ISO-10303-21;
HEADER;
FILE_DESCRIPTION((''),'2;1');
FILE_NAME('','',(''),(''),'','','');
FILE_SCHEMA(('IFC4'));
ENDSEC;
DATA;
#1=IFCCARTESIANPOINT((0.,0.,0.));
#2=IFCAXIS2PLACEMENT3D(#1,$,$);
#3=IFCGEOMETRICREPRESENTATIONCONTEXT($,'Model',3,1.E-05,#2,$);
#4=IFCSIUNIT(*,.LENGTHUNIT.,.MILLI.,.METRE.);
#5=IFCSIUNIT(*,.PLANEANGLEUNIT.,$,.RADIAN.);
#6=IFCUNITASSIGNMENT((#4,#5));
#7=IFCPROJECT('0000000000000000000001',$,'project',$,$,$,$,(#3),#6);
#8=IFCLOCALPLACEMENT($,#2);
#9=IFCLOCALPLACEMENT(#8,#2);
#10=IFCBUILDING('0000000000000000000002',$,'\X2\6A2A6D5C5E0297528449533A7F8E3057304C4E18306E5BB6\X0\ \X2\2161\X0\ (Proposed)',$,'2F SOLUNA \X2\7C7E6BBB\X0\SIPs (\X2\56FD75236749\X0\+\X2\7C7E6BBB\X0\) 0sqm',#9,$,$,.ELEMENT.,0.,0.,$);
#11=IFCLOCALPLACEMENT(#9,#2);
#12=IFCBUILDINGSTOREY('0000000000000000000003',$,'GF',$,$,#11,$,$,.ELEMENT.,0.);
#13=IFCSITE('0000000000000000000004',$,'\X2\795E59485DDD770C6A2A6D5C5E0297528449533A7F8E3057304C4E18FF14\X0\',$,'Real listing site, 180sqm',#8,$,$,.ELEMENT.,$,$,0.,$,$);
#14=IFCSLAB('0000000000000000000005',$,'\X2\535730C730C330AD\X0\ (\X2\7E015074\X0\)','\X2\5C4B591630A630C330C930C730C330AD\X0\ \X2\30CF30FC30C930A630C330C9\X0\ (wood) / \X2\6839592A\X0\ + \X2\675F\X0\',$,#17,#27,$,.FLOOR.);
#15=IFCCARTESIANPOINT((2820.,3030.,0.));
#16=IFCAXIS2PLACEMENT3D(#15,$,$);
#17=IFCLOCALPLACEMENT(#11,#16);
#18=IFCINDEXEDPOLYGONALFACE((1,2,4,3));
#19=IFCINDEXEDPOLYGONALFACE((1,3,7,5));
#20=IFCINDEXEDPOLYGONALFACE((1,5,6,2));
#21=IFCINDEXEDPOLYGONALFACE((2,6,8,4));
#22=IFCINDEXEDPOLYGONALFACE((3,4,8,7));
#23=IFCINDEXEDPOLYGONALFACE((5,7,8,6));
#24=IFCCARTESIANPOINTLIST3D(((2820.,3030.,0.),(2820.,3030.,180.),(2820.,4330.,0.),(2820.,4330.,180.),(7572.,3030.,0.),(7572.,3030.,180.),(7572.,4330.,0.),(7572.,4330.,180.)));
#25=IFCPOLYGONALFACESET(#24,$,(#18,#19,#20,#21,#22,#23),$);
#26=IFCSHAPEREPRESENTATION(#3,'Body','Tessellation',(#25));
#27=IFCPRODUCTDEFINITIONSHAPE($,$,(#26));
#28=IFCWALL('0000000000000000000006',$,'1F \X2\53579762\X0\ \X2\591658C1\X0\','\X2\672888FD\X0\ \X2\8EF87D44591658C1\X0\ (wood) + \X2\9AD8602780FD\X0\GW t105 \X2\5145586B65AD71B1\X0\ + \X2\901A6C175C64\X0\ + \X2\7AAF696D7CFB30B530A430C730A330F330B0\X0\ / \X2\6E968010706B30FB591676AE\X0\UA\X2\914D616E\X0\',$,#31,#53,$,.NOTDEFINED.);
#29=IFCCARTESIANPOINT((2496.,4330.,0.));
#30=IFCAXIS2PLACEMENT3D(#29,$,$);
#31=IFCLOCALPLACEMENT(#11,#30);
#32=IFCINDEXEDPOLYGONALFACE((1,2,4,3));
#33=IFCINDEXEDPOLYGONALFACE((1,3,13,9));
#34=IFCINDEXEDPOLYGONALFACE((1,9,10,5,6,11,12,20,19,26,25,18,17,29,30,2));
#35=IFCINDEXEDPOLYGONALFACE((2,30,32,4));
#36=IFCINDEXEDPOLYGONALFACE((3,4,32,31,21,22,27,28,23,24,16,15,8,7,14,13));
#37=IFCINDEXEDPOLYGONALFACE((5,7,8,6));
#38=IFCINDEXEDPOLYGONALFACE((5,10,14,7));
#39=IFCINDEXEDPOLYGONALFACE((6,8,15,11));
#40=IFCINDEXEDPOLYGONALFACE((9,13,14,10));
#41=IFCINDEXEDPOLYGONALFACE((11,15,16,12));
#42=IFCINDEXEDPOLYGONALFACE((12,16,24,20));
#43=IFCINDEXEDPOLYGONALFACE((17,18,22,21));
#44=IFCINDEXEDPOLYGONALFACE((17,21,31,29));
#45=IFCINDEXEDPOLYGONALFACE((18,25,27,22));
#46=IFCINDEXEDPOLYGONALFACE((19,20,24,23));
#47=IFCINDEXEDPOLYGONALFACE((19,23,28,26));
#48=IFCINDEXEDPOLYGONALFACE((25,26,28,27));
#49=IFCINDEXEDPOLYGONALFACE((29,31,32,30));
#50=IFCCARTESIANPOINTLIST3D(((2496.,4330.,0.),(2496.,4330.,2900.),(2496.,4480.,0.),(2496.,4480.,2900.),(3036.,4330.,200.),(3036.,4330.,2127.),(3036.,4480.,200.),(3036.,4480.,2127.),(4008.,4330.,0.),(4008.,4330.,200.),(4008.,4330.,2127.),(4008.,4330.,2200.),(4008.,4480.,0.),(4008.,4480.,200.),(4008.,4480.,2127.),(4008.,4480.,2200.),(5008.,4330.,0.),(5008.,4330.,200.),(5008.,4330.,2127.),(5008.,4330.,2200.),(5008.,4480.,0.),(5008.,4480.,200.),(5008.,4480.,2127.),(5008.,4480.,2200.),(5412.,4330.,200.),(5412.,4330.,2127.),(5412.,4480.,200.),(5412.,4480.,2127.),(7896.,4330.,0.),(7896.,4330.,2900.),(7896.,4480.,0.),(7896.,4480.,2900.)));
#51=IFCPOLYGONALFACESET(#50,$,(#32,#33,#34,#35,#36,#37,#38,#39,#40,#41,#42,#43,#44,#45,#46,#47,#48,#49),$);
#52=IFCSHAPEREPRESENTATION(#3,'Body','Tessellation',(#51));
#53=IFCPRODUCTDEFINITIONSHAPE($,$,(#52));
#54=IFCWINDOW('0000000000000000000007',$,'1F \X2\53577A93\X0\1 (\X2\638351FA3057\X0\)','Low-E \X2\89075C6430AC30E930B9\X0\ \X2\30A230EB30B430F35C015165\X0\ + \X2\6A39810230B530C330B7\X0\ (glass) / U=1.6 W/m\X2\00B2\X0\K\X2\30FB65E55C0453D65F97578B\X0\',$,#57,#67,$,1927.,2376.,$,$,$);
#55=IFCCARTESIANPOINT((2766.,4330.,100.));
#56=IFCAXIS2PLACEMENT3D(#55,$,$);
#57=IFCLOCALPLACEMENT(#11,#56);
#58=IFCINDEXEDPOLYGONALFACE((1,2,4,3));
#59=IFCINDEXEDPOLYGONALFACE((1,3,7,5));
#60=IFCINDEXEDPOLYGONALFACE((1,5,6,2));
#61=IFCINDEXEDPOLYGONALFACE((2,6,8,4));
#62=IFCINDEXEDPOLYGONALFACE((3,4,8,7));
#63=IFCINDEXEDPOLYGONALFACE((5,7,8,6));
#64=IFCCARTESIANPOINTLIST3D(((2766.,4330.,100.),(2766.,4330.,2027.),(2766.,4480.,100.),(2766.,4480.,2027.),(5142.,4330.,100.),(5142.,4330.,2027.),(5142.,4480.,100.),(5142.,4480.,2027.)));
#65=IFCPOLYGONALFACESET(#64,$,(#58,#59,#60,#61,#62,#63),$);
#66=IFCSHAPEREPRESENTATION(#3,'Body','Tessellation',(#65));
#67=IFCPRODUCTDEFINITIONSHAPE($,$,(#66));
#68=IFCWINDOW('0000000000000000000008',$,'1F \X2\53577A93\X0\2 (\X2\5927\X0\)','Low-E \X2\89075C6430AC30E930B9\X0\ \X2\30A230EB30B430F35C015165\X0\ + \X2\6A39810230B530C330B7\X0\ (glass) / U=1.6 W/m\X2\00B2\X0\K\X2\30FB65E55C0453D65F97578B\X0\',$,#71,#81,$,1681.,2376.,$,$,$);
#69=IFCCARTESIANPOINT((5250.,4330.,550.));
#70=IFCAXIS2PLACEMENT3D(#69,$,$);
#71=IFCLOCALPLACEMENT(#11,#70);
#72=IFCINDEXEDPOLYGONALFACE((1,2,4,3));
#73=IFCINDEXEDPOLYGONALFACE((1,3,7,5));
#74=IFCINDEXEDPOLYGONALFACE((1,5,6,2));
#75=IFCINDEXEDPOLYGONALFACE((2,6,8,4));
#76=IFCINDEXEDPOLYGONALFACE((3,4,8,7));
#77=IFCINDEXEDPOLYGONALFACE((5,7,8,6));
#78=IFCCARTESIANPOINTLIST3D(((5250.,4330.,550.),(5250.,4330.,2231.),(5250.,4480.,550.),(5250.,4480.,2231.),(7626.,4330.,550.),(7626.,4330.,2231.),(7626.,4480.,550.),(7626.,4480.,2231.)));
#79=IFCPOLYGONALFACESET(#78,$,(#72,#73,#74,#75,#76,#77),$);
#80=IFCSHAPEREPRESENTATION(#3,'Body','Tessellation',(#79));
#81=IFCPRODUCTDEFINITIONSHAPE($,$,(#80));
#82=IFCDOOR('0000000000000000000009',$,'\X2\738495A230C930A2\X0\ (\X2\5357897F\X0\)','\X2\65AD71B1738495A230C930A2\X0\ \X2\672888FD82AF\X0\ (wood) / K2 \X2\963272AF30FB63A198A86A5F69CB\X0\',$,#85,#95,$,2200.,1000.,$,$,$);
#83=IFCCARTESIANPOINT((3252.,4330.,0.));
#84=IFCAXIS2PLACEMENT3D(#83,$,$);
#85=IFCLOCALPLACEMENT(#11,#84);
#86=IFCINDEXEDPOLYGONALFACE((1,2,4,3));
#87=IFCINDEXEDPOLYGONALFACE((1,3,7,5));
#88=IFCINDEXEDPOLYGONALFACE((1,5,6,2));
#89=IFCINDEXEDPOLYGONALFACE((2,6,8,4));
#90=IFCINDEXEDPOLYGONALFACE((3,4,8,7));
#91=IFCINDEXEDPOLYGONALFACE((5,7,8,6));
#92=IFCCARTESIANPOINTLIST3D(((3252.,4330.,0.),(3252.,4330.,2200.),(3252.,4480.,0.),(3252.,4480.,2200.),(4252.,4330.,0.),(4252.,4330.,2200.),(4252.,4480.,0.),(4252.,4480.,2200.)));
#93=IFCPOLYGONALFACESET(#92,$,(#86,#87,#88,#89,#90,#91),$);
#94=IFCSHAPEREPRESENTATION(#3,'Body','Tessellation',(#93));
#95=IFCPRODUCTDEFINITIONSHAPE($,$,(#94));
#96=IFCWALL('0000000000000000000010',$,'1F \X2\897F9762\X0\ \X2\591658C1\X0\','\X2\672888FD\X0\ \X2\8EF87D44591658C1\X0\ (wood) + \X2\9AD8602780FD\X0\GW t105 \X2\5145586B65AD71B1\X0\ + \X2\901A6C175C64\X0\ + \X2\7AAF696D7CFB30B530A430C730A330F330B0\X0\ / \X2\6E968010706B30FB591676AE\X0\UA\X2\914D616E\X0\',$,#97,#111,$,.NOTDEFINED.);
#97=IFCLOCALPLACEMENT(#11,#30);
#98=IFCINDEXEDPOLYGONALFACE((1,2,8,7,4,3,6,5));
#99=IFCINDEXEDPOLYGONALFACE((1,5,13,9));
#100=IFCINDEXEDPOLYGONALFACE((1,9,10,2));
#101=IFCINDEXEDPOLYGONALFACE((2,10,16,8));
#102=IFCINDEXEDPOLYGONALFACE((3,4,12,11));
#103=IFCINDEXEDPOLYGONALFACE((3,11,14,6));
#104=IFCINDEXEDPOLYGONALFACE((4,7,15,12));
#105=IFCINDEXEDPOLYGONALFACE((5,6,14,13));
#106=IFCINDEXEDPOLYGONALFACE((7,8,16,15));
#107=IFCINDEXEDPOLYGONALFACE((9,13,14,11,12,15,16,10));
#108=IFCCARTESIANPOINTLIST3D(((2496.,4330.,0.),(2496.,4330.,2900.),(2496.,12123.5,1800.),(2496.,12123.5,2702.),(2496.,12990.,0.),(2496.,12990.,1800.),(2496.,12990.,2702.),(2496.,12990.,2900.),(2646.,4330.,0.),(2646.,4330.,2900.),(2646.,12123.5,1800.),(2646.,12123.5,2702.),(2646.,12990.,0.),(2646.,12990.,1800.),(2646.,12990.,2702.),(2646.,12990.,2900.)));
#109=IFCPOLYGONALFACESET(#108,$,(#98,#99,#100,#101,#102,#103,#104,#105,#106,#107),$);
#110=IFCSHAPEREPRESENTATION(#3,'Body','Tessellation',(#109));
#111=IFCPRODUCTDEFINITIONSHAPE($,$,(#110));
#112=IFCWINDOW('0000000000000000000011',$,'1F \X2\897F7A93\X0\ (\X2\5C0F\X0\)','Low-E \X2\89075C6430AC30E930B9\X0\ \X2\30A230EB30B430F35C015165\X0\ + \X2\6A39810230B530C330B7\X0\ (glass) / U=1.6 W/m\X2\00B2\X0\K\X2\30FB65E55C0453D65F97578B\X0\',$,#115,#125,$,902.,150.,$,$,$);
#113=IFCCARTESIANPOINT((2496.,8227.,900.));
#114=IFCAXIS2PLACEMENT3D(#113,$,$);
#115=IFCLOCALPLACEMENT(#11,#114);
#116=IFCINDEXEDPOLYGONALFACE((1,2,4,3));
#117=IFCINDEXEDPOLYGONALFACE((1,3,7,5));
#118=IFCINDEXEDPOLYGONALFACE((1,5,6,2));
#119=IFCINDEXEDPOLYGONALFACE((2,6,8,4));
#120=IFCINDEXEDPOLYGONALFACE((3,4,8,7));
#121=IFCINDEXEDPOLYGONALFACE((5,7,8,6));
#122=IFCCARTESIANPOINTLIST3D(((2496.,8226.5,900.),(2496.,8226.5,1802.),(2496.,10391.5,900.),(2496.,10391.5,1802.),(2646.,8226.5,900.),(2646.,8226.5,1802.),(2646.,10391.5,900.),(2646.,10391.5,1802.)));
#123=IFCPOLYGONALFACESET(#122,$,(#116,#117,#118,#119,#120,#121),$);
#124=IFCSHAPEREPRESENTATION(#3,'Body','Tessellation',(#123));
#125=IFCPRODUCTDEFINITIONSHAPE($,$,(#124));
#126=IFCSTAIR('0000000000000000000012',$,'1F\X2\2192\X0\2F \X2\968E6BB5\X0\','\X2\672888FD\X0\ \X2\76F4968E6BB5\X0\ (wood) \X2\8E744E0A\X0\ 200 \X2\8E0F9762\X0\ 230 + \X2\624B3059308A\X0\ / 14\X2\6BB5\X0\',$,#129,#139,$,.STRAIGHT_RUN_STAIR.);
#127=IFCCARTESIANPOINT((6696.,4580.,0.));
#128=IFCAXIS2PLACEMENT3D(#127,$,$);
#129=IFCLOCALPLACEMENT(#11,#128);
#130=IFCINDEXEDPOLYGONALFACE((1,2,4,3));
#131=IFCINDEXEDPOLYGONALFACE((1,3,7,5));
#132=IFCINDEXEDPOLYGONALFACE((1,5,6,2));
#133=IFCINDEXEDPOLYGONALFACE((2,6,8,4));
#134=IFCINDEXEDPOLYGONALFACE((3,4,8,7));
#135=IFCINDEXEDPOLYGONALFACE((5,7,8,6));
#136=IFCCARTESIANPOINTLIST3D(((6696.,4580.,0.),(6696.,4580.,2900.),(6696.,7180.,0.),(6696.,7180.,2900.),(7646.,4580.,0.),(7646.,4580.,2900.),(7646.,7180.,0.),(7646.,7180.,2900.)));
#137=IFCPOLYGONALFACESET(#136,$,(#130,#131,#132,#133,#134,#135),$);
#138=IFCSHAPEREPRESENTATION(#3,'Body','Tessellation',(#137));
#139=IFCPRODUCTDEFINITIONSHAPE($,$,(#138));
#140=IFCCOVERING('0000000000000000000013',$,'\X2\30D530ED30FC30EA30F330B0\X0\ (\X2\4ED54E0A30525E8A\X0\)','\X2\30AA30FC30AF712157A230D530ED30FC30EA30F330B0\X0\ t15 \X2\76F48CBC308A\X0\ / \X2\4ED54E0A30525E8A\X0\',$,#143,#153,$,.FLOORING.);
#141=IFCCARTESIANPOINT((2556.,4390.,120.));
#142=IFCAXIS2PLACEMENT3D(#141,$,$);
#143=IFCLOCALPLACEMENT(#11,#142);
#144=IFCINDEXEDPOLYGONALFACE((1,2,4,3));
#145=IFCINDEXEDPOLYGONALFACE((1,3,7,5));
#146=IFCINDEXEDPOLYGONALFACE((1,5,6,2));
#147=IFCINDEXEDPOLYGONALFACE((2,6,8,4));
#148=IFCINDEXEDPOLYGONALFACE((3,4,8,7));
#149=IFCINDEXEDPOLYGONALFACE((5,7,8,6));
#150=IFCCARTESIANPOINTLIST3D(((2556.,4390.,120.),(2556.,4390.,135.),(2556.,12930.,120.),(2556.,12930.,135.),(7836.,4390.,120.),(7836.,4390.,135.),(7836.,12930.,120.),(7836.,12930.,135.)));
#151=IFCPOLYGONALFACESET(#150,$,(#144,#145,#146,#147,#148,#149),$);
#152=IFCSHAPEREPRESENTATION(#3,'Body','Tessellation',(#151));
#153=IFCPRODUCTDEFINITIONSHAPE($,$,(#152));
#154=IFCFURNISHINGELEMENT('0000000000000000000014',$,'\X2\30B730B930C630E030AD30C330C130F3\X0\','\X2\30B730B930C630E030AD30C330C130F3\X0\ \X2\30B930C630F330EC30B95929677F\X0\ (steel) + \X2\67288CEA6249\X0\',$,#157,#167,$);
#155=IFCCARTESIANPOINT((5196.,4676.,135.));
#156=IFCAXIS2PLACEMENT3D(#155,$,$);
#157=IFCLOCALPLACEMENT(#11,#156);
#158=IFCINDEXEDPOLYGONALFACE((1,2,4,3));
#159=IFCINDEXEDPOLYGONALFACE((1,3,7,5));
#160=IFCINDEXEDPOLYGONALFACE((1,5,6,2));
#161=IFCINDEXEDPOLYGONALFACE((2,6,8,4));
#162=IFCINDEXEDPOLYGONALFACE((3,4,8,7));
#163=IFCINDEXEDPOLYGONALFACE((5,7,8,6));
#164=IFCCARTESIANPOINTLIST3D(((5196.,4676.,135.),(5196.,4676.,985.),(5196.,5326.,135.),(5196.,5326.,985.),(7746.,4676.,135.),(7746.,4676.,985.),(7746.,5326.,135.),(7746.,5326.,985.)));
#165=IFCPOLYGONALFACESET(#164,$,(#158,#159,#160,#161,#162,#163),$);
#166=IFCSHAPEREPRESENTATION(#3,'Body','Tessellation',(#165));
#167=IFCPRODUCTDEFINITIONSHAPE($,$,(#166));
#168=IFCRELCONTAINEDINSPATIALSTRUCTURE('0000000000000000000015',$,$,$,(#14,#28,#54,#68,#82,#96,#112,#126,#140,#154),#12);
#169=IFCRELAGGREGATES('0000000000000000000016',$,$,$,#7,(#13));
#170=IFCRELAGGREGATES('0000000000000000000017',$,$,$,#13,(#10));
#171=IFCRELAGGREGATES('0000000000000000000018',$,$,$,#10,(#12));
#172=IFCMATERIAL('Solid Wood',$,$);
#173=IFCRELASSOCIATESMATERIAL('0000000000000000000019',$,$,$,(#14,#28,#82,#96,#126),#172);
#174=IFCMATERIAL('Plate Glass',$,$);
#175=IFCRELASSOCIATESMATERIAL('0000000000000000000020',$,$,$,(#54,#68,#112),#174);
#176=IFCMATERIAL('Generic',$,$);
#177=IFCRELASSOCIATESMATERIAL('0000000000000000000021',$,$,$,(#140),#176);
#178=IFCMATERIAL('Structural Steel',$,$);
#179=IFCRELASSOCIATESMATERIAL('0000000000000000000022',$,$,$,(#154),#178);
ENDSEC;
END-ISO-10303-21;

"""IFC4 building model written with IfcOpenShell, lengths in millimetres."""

from ifc_helpers import new_model, si_unit, frame, frame_2d, origin, place, context, project, spatial, rectangle, extrude, material, element, fill, save


model = new_model("IFC4")

# Units and contexts
model_context = context("Model", 3, precision=1e-05, world=origin())
ifc_project = project(units=[si_unit("LENGTHUNIT", "METRE", prefix="MILLI"), si_unit("PLANEANGLEUNIT", "RADIAN")], contexts=[model_context])

# Site, building, storey
site_placement = place(None, origin())
site = spatial("IfcSite", under=ifc_project, at=site_placement, Name="神奈川県横浜市青葉区美しが丘４", ObjectType="Real listing site, 180sqm", CompositionType="ELEMENT", RefElevation=0.0)
building_placement = place(site_placement, origin())
building = spatial("IfcBuilding", under=site, at=building_placement, Name="横浜市青葉区美しが丘の家 Ⅱ (Proposed)", ObjectType="2F SOLUNA 籾殻SIPs (国産杉+籾殻) 0sqm", CompositionType="ELEMENT", ElevationOfRefHeight=0.0, ElevationOfTerrain=0.0)
storey_placement = place(building_placement, origin())
storey = spatial("IfcBuildingStorey", under=building, at=storey_placement, Name="GF", CompositionType="ELEMENT", Elevation=0.0)

# Slab
ifc_material_1 = material(Name="Solid Wood")
slab_1_placement = place(storey_placement, frame((2820.0, 3030.0, 0.0)))
element("IfcSlab", 1, at=slab_1_placement, inside=storey, material=ifc_material_1, Name="南デッキ (縁側)", Description="屋外ウッドデッキ ハードウッド (wood) / 根太 + 束", PredefinedType="FLOOR", context=model_context, shape_type="SweptSolid", body=[
    extrude(rectangle(XDim=4752.0, YDim=1300.0, at=frame_2d((2376.0, 650.0))), frame((2820.0, 3030.0, 0.0)), (0.0, 0.0, 1.0), 180.0),
])

# Wall, openings, windows, door
wall_1_placement = place(storey_placement, frame((2496.0, 4330.0, 0.0)))
wall_1 = element("IfcWall", 2, at=wall_1_placement, inside=storey, material=ifc_material_1, Name="1F 南面 外壁", Description="木製 軸組外壁 (wood) + 高性能GW t105 充填断熱 + 通気層 + 窯業系サイディング / 準耐火・外皮UA配慮", PredefinedType="NOTDEFINED", context=model_context, shape_type="SweptSolid", body=[
    extrude(rectangle(XDim=5400.0, YDim=150.0, at=frame_2d((2700.0, 75.0))), frame((2496.0, 4330.0, 0.0)), (0.0, 0.0, 1.0), 2900.0),
])
opening_1_placement = place(storey_placement, frame((2766.0, 4330.0, 100.0)))
opening_1 = element("IfcOpeningElement", 3, at=opening_1_placement, cuts=wall_1, PredefinedType="NOTDEFINED", context=model_context, shape_type="SweptSolid", body=[
    extrude(rectangle(XDim=2376.0, YDim=150.0, at=frame_2d((1188.0, 75.0))), frame((2766.0, 4330.0, 100.0)), (0.0, 0.0, 1.0), 1927.0),
])
opening_2_placement = place(storey_placement, frame((5250.0, 4330.0, 550.0)))
opening_2 = element("IfcOpeningElement", 4, at=opening_2_placement, cuts=wall_1, PredefinedType="NOTDEFINED", context=model_context, shape_type="SweptSolid", body=[
    extrude(rectangle(XDim=2376.0, YDim=150.0, at=frame_2d((1188.0, 75.0))), frame((5250.0, 4330.0, 550.0)), (0.0, 0.0, 1.0), 1681.0),
])
opening_3_placement = place(storey_placement, frame((3252.0, 4330.0, 0.0)))
opening_3 = element("IfcOpeningElement", 5, at=opening_3_placement, cuts=wall_1, PredefinedType="NOTDEFINED", context=model_context, shape_type="SweptSolid", body=[
    extrude(rectangle(XDim=1000.0, YDim=150.0, at=frame_2d((500.0, 75.0))), frame((3252.0, 4330.0, 0.0)), (0.0, 0.0, 1.0), 2200.0),
])
ifc_material_2 = material(Name="Plate Glass")
window_1_placement = place(storey_placement, frame((2766.0, 4330.0, 100.0)))
window_1 = element("IfcWindow", 6, at=window_1_placement, inside=storey, material=ifc_material_2, Name="1F 南窓1 (掃出し)", Description="Low-E 複層ガラス アルゴン封入 + 樹脂サッシ (glass) / U=1.6 W/m²K・日射取得型", OverallHeight=1927.0, OverallWidth=2376.0, context=model_context, shape_type="SweptSolid", body=[
    extrude(rectangle(XDim=2376.0, YDim=150.0, at=frame_2d((1188.0, 75.0))), frame((2766.0, 4330.0, 100.0)), (0.0, 0.0, 1.0), 1927.0),
])
fill(opening_1, window_1)
window_2_placement = place(storey_placement, frame((5250.0, 4330.0, 550.0)))
window_2 = element("IfcWindow", 7, at=window_2_placement, inside=storey, material=ifc_material_2, Name="1F 南窓2 (大)", Description="Low-E 複層ガラス アルゴン封入 + 樹脂サッシ (glass) / U=1.6 W/m²K・日射取得型", OverallHeight=1681.0, OverallWidth=2376.0, context=model_context, shape_type="SweptSolid", body=[
    extrude(rectangle(XDim=2376.0, YDim=150.0, at=frame_2d((1188.0, 75.0))), frame((5250.0, 4330.0, 550.0)), (0.0, 0.0, 1.0), 1681.0),
])
fill(opening_2, window_2)
door_placement = place(storey_placement, frame((3252.0, 4330.0, 0.0)))
door = element("IfcDoor", 8, at=door_placement, inside=storey, material=ifc_material_1, Name="玄関ドア (南西)", Description="断熱玄関ドア 木製芯 (wood) / K2 防犯・採風機構", OverallHeight=2200.0, OverallWidth=1000.0, context=model_context, shape_type="SweptSolid", body=[
    extrude(rectangle(XDim=1000.0, YDim=150.0, at=frame_2d((500.0, 75.0))), frame((3252.0, 4330.0, 0.0)), (0.0, 0.0, 1.0), 2200.0),
])
fill(opening_3, door)

# Wall, opening, window
wall_2_placement = place(storey_placement, frame((2496.0, 4330.0, 0.0)))
wall_2 = element("IfcWall", 9, at=wall_2_placement, inside=storey, material=ifc_material_1, Name="1F 西面 外壁", Description="木製 軸組外壁 (wood) + 高性能GW t105 充填断熱 + 通気層 + 窯業系サイディング / 準耐火・外皮UA配慮", PredefinedType="NOTDEFINED", context=model_context, shape_type="SweptSolid", body=[
    extrude(rectangle(XDim=150.0, YDim=8660.0, at=frame_2d((75.0, 4330.0))), frame((2496.0, 4330.0, 0.0)), (0.0, 0.0, 1.0), 2900.0),
])
opening_4_placement = place(storey_placement, frame((2496.0, 8227.0, 900.0)))
opening_4 = element("IfcOpeningElement", 10, at=opening_4_placement, cuts=wall_2, PredefinedType="NOTDEFINED", context=model_context, shape_type="SweptSolid", body=[
    extrude(rectangle(XDim=150.0, YDim=2165.0, at=frame_2d((75.0, 1082.0))), frame((2496.0, 8227.0, 900.0)), (0.0, 0.0, 1.0), 902.0),
])
window_3_placement = place(storey_placement, frame((2496.0, 8227.0, 900.0)))
window_3 = element("IfcWindow", 11, at=window_3_placement, inside=storey, material=ifc_material_2, Name="1F 西窓 (小)", Description="Low-E 複層ガラス アルゴン封入 + 樹脂サッシ (glass) / U=1.6 W/m²K・日射取得型", OverallHeight=902.0, OverallWidth=150.0, context=model_context, shape_type="SweptSolid", body=[
    extrude(rectangle(XDim=150.0, YDim=2165.0, at=frame_2d((75.0, 1082.0))), frame((2496.0, 8227.0, 900.0)), (0.0, 0.0, 1.0), 902.0),
])
fill(opening_4, window_3)

# Stair
stair_placement = place(storey_placement, frame((6696.0, 4580.0, 0.0)))
element("IfcStair", 12, at=stair_placement, inside=storey, material=ifc_material_1, Name="1F→2F 階段", Description="木製 直階段 (wood) 蹴上 200 踏面 230 + 手すり / 14段", PredefinedType="STRAIGHT_RUN_STAIR", context=model_context, shape_type="SweptSolid", body=[
    extrude(rectangle(XDim=950.0, YDim=2600.0, at=frame_2d((475.0, 1300.0))), frame((6696.0, 4580.0, 0.0)), (0.0, 0.0, 1.0), 2900.0),
])

# Covering
ifc_material_3 = material(Name="Generic")
covering_placement = place(storey_placement, frame((2556.0, 4390.0, 120.0)))
element("IfcCovering", 13, at=covering_placement, inside=storey, material=ifc_material_3, Name="フローリング (仕上げ床)", Description="オーク無垢フローリング t15 直貼り / 仕上げ床", PredefinedType="FLOORING", context=model_context, shape_type="SweptSolid", body=[
    extrude(rectangle(XDim=5280.0, YDim=8540.0, at=frame_2d((2640.0, 4270.0))), frame((2556.0, 4390.0, 120.0)), (0.0, 0.0, 1.0), 15.0),
])

# Furnishing element
ifc_material_4 = material(Name="Structural Steel")
furnishing_placement = place(storey_placement, frame((5196.0, 4676.0, 135.0)))
element("IfcFurnishingElement", 14, at=furnishing_placement, inside=storey, material=ifc_material_4, Name="システムキッチン", Description="システムキッチン ステンレス天板 (steel) + 木質扉", context=model_context, shape_type="SweptSolid", body=[
    extrude(rectangle(XDim=2550.0, YDim=650.0, at=frame_2d((1275.0, 325.0))), frame((5196.0, 4676.0, 135.0)), (0.0, 0.0, 1.0), 850.0),
])

save(model, "model.ifc")
